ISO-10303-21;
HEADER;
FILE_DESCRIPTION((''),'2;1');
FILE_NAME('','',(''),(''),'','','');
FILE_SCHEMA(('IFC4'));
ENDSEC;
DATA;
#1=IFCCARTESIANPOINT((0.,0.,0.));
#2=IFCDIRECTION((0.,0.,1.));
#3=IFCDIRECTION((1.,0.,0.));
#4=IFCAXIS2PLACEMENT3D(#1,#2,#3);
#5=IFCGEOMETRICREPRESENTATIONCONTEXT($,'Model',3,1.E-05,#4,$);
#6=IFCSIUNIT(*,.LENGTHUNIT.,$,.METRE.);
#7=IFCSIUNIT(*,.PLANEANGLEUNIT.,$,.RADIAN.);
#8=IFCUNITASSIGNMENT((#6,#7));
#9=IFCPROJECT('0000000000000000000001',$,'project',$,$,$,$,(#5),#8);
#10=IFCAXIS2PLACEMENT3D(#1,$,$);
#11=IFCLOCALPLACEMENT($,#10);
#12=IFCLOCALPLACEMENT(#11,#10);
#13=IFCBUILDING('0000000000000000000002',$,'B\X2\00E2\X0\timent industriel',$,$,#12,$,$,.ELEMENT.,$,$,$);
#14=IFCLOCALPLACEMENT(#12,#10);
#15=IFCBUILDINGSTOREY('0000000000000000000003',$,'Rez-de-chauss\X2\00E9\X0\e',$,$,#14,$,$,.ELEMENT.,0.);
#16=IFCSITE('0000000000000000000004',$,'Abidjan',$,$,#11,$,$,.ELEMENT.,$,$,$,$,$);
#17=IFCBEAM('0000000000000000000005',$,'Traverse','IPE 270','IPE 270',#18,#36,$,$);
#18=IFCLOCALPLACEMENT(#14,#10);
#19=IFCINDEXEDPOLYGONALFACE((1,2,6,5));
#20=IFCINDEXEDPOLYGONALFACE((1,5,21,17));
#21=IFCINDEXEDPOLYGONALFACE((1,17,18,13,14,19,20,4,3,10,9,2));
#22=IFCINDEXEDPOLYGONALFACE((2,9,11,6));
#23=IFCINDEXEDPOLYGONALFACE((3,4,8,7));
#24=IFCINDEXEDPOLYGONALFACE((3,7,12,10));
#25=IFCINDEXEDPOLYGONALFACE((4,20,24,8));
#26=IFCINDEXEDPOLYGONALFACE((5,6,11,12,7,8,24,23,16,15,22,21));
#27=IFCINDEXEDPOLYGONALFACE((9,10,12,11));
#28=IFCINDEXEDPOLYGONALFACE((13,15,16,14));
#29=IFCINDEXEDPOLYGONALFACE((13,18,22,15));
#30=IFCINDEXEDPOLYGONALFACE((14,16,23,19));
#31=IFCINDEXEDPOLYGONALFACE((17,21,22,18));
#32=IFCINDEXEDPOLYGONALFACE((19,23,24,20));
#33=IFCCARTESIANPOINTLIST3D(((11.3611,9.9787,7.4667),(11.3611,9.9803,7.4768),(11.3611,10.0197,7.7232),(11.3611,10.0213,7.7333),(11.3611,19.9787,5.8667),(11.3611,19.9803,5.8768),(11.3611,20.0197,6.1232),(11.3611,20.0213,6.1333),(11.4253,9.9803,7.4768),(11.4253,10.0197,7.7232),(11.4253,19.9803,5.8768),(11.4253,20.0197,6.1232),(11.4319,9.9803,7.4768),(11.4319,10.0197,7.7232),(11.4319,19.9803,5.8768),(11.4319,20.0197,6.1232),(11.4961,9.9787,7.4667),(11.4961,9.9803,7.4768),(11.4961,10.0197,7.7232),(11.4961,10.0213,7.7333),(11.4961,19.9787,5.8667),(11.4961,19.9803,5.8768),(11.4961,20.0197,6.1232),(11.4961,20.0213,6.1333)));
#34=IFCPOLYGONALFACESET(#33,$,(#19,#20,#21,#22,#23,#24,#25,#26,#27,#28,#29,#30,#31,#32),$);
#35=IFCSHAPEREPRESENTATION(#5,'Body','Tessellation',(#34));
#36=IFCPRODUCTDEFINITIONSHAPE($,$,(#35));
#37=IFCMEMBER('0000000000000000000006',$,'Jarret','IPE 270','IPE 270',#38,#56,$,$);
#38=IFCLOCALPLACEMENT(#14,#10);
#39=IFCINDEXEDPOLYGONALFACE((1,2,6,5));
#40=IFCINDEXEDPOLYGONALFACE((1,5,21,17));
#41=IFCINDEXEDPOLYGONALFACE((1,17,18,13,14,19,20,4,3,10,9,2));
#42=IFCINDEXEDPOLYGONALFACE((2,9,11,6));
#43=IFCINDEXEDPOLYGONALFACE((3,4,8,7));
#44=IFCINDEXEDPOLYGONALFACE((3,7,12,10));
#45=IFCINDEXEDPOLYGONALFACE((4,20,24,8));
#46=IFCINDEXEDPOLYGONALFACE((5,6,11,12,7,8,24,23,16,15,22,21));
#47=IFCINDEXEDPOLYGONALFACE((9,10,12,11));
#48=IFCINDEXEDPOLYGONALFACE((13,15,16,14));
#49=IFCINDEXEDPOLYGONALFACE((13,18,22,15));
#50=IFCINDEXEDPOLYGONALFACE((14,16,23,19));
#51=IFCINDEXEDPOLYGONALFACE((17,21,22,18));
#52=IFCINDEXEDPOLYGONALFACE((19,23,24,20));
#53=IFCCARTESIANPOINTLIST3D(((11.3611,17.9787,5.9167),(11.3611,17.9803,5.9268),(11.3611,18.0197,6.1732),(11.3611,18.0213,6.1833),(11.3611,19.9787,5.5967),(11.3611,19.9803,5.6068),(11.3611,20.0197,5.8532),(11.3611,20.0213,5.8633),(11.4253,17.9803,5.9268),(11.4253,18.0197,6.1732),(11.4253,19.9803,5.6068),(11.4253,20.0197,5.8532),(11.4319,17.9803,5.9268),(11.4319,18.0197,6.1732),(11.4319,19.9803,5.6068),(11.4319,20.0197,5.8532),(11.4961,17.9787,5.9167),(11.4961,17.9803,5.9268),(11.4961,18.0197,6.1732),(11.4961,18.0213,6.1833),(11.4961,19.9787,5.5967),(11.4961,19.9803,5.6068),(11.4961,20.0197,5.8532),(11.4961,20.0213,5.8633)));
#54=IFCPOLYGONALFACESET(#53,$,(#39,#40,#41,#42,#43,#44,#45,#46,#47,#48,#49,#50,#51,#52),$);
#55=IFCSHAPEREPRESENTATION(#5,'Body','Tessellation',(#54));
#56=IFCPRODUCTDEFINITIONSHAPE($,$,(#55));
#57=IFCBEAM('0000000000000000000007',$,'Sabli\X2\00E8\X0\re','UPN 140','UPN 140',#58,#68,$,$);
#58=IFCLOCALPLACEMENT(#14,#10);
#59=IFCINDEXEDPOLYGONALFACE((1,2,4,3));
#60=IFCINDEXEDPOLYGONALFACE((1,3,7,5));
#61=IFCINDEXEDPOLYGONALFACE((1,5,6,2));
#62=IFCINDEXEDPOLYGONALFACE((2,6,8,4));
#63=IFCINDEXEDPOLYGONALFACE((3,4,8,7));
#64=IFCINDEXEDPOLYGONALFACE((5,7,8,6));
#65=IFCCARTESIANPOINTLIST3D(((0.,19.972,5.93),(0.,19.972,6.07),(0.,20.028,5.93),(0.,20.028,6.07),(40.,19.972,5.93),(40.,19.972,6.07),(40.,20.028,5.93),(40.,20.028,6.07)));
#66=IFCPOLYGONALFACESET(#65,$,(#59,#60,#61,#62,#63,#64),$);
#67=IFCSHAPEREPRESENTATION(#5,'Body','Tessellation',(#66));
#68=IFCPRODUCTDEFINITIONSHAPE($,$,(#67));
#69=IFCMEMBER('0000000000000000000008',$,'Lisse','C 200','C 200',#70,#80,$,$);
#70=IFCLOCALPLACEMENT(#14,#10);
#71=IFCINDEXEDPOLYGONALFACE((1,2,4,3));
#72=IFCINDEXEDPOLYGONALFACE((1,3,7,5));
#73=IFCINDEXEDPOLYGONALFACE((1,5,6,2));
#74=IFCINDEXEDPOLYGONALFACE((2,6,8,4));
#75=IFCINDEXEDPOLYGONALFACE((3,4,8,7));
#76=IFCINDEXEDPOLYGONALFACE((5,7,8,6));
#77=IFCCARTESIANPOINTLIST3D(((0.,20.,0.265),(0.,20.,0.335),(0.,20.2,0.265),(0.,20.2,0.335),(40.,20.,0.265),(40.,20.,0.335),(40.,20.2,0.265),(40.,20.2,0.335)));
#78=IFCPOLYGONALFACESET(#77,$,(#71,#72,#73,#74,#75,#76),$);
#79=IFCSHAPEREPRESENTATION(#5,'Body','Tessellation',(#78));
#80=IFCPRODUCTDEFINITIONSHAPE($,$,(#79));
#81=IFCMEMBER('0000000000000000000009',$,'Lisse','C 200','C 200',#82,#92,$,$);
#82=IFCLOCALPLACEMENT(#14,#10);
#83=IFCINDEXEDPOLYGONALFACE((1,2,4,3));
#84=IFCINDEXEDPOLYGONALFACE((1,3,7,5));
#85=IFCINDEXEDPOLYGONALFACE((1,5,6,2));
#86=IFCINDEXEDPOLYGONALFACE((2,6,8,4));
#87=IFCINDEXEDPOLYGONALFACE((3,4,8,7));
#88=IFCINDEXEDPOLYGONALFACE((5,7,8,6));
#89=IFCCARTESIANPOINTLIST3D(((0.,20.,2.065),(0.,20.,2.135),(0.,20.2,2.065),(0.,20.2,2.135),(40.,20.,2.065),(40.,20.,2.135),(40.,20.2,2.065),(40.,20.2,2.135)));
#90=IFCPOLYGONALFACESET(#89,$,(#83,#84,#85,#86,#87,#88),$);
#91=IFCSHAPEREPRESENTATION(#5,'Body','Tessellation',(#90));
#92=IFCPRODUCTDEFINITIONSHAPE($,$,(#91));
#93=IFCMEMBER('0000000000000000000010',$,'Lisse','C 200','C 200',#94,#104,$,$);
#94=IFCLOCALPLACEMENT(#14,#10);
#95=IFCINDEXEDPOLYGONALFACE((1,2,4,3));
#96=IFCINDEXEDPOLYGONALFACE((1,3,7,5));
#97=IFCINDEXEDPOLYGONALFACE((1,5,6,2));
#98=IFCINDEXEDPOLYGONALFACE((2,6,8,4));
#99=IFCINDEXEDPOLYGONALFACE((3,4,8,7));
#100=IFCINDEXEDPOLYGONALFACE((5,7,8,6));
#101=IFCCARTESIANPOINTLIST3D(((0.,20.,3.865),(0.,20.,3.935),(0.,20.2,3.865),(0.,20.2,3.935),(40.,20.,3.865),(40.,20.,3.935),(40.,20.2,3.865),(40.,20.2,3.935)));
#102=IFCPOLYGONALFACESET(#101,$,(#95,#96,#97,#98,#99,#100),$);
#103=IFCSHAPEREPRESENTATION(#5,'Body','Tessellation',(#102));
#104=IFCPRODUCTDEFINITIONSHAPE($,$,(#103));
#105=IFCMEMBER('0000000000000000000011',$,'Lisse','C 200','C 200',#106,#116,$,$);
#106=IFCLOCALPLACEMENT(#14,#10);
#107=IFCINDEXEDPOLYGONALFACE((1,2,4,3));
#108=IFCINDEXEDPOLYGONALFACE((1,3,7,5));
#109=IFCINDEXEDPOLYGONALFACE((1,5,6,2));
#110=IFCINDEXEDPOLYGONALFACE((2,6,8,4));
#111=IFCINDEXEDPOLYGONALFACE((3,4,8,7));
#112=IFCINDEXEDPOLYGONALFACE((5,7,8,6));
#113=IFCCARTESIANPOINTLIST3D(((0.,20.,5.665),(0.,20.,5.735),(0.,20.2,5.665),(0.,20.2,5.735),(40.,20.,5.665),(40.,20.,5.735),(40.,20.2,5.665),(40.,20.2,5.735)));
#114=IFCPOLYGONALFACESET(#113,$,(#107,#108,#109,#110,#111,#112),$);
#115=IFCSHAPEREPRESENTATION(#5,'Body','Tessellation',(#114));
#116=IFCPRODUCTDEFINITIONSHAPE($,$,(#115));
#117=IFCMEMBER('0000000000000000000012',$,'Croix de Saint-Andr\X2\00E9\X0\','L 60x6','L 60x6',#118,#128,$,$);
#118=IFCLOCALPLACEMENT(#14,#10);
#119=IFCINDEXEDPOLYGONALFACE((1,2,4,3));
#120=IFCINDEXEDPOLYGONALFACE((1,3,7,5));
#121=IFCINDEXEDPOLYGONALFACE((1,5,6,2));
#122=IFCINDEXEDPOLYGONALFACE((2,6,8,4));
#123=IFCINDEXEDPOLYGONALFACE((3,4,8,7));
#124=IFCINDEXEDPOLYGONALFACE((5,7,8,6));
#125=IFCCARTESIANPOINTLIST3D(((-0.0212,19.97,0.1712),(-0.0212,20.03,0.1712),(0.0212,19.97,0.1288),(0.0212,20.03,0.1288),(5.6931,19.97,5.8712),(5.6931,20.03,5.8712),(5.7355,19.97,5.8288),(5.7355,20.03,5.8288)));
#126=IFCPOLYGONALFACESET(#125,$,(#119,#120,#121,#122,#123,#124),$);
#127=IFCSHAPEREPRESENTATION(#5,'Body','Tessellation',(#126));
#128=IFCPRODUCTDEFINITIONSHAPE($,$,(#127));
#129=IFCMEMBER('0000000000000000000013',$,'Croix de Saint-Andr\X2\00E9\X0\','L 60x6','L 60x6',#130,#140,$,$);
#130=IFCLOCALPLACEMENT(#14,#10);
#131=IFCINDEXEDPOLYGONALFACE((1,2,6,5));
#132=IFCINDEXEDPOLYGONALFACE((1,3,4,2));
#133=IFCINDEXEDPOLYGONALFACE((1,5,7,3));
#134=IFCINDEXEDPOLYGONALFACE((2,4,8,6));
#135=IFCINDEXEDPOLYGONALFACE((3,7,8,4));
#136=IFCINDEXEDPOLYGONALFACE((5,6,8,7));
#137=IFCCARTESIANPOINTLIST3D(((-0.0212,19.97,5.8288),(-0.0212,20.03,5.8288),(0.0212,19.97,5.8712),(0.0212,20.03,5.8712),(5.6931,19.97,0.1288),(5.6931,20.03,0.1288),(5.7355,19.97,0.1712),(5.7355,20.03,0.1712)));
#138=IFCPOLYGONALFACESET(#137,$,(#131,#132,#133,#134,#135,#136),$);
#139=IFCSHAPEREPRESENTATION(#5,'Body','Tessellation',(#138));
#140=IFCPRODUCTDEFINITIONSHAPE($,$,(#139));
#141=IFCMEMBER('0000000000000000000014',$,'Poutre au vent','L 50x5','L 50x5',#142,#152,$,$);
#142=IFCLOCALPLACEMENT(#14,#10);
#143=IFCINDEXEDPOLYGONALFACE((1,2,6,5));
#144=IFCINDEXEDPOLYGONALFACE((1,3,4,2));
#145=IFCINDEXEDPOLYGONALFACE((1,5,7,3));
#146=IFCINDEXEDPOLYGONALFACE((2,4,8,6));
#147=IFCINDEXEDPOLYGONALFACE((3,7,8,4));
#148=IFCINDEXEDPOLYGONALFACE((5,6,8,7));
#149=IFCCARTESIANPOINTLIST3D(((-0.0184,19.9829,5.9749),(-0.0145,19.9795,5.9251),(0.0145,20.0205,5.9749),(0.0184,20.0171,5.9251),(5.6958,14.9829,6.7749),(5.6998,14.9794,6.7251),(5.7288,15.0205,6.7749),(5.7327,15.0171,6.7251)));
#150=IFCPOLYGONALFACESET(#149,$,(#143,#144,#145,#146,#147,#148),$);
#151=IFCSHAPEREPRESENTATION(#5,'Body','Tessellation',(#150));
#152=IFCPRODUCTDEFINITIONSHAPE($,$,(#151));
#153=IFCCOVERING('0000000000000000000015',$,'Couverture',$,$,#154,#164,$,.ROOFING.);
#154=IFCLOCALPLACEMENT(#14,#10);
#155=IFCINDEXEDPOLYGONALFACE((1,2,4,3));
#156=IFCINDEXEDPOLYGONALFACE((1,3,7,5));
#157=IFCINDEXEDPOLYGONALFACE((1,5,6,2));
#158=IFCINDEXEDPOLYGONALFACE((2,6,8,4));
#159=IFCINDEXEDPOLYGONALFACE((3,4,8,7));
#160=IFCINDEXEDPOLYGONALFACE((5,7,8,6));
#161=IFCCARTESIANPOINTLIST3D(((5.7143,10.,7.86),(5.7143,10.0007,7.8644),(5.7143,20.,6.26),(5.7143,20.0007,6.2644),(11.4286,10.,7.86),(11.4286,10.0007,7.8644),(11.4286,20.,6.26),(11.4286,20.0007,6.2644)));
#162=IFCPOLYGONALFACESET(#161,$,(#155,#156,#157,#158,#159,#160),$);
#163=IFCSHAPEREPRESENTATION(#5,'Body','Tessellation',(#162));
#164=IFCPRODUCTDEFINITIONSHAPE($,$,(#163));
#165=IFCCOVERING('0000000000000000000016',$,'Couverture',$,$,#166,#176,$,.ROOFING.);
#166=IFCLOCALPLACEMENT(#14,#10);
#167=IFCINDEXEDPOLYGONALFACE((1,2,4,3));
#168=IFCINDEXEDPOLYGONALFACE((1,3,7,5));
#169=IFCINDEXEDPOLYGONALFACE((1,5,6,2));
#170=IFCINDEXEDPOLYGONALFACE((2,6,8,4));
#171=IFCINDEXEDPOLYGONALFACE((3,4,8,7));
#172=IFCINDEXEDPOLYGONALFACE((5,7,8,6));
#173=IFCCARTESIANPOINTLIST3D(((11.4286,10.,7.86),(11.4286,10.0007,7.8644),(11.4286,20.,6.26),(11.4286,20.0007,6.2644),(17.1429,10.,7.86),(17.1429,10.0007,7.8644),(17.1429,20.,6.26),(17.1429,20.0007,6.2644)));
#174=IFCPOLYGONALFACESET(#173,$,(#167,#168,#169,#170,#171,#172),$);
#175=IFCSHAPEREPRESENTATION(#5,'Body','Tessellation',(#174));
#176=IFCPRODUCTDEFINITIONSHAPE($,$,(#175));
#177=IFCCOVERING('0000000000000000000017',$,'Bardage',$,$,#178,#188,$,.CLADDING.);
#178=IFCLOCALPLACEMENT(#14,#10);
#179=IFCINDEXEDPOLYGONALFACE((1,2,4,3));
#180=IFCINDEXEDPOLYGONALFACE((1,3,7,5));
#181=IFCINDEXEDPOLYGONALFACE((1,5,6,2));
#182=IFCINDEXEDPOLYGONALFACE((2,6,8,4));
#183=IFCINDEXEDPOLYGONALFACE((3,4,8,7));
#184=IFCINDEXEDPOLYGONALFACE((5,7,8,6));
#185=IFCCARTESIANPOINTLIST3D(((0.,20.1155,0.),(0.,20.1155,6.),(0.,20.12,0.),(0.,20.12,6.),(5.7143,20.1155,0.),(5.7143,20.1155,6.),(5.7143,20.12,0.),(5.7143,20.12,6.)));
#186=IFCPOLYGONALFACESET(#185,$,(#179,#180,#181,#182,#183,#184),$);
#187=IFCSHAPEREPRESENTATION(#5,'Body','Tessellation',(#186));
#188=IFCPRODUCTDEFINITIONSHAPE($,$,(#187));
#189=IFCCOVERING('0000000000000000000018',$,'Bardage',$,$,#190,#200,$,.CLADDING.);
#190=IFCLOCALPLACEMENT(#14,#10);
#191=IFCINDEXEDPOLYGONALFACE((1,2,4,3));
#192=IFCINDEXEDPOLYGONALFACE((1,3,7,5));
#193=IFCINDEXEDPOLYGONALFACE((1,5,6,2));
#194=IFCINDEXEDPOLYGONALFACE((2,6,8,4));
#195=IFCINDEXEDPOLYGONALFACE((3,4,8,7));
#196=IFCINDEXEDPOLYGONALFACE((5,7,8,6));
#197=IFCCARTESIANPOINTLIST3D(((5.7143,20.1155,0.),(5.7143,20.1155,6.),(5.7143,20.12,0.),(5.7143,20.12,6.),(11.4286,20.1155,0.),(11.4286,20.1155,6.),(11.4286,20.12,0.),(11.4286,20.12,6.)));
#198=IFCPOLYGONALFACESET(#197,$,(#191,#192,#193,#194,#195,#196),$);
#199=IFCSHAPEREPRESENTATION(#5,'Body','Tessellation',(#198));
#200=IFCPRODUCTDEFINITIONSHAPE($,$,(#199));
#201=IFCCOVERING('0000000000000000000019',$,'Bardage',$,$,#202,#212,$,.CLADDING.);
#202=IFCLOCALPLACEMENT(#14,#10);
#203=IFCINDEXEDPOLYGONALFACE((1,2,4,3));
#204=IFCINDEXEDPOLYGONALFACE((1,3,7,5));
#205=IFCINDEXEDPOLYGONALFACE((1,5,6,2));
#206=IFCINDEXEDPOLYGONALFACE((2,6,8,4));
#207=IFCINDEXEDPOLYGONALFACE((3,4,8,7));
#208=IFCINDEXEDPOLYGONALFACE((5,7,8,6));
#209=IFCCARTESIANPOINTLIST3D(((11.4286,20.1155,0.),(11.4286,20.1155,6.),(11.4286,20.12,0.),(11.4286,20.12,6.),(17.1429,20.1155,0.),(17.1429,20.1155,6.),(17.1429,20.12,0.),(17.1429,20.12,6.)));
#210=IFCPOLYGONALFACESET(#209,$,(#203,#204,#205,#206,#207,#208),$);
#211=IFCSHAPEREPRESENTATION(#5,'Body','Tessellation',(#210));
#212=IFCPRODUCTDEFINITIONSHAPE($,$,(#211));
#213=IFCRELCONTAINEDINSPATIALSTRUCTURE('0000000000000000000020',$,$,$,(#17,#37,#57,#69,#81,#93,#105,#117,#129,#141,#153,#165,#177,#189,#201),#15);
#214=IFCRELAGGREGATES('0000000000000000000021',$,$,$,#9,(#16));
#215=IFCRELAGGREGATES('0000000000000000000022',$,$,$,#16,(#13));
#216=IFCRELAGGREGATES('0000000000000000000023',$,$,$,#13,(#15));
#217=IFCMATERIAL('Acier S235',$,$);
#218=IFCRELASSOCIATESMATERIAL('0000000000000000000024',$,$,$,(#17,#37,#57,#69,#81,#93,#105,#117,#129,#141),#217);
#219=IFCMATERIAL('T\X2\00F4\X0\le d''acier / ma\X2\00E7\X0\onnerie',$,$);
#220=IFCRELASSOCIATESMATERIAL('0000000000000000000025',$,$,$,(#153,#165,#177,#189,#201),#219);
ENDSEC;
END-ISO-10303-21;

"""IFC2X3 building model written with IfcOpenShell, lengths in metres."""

from ifc_helpers import new_model, si_unit, frame, origin, origin_with_axes, origin_2d, place, context, project, spatial, polyline, rectangle, i_section, outline, extrude, material, element, save


model = new_model("IFC2X3")

# Units and contexts
model_context = context("Model", 3, precision=1e-05, world=origin_with_axes())
ifc_project = project(units=[si_unit("LENGTHUNIT", "METRE"), si_unit("PLANEANGLEUNIT", "RADIAN")], contexts=[model_context])

# Site, building, storey
site_placement = place(None, origin())
site = spatial("IfcSite", under=ifc_project, at=site_placement, Name="Abidjan", CompositionType="ELEMENT")
building_placement = place(site_placement, origin())
building = spatial("IfcBuilding", under=site, at=building_placement, Name="Bâtiment industriel", CompositionType="ELEMENT")
storey_placement = place(building_placement, origin())
storey = spatial("IfcBuildingStorey", under=building, at=storey_placement, Name="Rez-de-chaussée", CompositionType="ELEMENT", Elevation=0.0)

# Shared definitions
ifc_material_1 = material(Name="Acier S235")

# Beam
beam_1_placement = place(storey_placement, frame((11.4286, 10.0, 7.6), z_axis=(0.0, 0.98744, -0.15799), x_axis=(1.0, 0.0, 0.0)))
element("IfcBeam", 1, at=beam_1_placement, inside=storey, material=ifc_material_1, Name="Traverse", Description="IPE 270", ObjectType="IPE 270", context=model_context, shape_type="SweptSolid", body=[
    extrude(i_section(OverallWidth=0.135, OverallDepth=0.27, WebThickness=0.0066, FlangeThickness=0.0102, at=origin_2d()), origin(), (0.0, 0.0, 1.0), 10.1272),
])

# Member
member_1_placement = place(storey_placement, frame((11.4286, 20.0, 5.73), z_axis=(0.0, -0.98744, 0.15799), x_axis=(1.0, 0.0, 0.0)))
element("IfcMember", 2, at=member_1_placement, inside=storey, material=ifc_material_1, Name="Jarret", Description="IPE 270", ObjectType="IPE 270", context=model_context, shape_type="SweptSolid", body=[
    extrude(i_section(OverallWidth=0.135, OverallDepth=0.27, WebThickness=0.0066, FlangeThickness=0.0102, at=origin_2d()), origin(), (0.0, 0.0, 1.0), 2.0254),
])

# Beam
beam_2_placement = place(storey_placement, frame((0.0, 20.0, 6.0), z_axis=(1.0, 0.0, 0.0), x_axis=(0.0, 1.0, 0.0)))
element("IfcBeam", 3, at=beam_2_placement, inside=storey, material=ifc_material_1, Name="Sablière", Description="UPN 140", ObjectType="UPN 140", context=model_context, shape_type="SweptSolid", body=[
    extrude(rectangle(XDim=0.056, YDim=0.14, at=origin_2d()), origin(), (0.0, 0.0, 1.0), 40.0),
])

# Members
for number, where, z_axis, x_axis, name in (
    (4, (0.0, 20.1, 0.3), (1.0, 0.0, 0.0), (0.0, 0.0, 1.0), "Lisse"),
    (5, (0.0, 20.1, 2.1), (1.0, 0.0, 0.0), (0.0, 0.0, 1.0), "Lisse"),
    (6, (0.0, 20.1, 3.9), (1.0, 0.0, 0.0), (0.0, 0.0, 1.0), "Lisse"),
    (7, (0.0, 20.1, 5.7), (1.0, 0.0, 0.0), (0.0, 0.0, 1.0), "Lisse"),
):
    element("IfcMember", number, at=place(storey_placement, frame(where, z_axis=z_axis, x_axis=x_axis)), inside=storey, material=ifc_material_1, Name=name, Description="C 200", ObjectType="C 200", context=model_context, shape_type="SweptSolid", body=[
        extrude(rectangle(XDim=0.07, YDim=0.2, at=origin_2d()), origin(), (0.0, 0.0, 1.0), 40.0),
    ])
for number, where, z_axis, x_axis, name in (
    (8, (0.0, 20.0, 0.15), (0.70799, 0.0, 0.70622), (0.0, 1.0, 0.0), "Croix de Saint-André"),
    (9, (5.7143, 20.0, 0.15), (-0.70799, 0.0, 0.70622), (0.0, 1.0, 0.0), "Croix de Saint-André"),
):
    element("IfcMember", number, at=place(storey_placement, frame(where, z_axis=z_axis, x_axis=x_axis)), inside=storey, material=ifc_material_1, Name=name, Description="L 60x6", ObjectType="L 60x6", context=model_context, shape_type="SweptSolid", body=[
        extrude(rectangle(XDim=0.06, YDim=0.06, at=origin_2d()), origin(), (0.0, 0.0, 1.0), 8.0711),
    ])
member_2_placement = place(storey_placement, frame((0.0, 20.0, 5.95), z_axis=(0.74843, -0.65488, 0.10478), x_axis=(-0.07886, 0.069, 0.9945)))
element("IfcMember", 10, at=member_2_placement, inside=storey, material=ifc_material_1, Name="Poutre au vent", Description="L 50x5", ObjectType="L 50x5", context=model_context, shape_type="SweptSolid", body=[
    extrude(rectangle(XDim=0.05, YDim=0.05, at=origin_2d()), origin(), (0.0, 0.0, 1.0), 7.635),
])

# Coverings
ifc_material_2 = material(Name="Tôle d'acier / maçonnerie")
for number, where, z_axis, x_axis, name in (
    (11, (5.7143, 10.0, 7.86), (0.0, 0.15799, 0.98744), (1.0, 0.0, 0.0), "Couverture"),
    (12, (11.4286, 10.0, 7.86), (0.0, 0.15799, 0.98744), (1.0, 0.0, 0.0), "Couverture"),
):
    element("IfcCovering", number, at=place(storey_placement, frame(where, z_axis=z_axis, x_axis=x_axis)), inside=storey, material=ifc_material_2, Name=name, PredefinedType="ROOFING", context=model_context, shape_type="SweptSolid", body=[
        extrude(outline(polyline([(0.0, 0.0), (5.7143, 0.0), (5.7143, 10.1272), (0.0, 10.1272), (0.0, 0.0)])), origin(), (0.0, 0.0, 1.0), 0.0045),
    ])
for number, where, z_axis, x_axis, name in (
    (13, (0.0, 20.12, 0.0), (0.0, -1.0, 0.0), (1.0, 0.0, 0.0), "Bardage"),
    (14, (5.7143, 20.12, 0.0), (0.0, -1.0, 0.0), (1.0, 0.0, 0.0), "Bardage"),
    (15, (11.4286, 20.12, 0.0), (0.0, -1.0, 0.0), (1.0, 0.0, 0.0), "Bardage"),
):
    element("IfcCovering", number, at=place(storey_placement, frame(where, z_axis=z_axis, x_axis=x_axis)), inside=storey, material=ifc_material_2, Name=name, PredefinedType="CLADDING", context=model_context, shape_type="SweptSolid", body=[
        extrude(outline(polyline([(0.0, 0.0), (5.7143, 0.0), (5.7143, 6.0), (0.0, 6.0), (0.0, 0.0)])), origin(), (0.0, 0.0, 1.0), 0.0045),
    ])

save(model, "model.ifc")
